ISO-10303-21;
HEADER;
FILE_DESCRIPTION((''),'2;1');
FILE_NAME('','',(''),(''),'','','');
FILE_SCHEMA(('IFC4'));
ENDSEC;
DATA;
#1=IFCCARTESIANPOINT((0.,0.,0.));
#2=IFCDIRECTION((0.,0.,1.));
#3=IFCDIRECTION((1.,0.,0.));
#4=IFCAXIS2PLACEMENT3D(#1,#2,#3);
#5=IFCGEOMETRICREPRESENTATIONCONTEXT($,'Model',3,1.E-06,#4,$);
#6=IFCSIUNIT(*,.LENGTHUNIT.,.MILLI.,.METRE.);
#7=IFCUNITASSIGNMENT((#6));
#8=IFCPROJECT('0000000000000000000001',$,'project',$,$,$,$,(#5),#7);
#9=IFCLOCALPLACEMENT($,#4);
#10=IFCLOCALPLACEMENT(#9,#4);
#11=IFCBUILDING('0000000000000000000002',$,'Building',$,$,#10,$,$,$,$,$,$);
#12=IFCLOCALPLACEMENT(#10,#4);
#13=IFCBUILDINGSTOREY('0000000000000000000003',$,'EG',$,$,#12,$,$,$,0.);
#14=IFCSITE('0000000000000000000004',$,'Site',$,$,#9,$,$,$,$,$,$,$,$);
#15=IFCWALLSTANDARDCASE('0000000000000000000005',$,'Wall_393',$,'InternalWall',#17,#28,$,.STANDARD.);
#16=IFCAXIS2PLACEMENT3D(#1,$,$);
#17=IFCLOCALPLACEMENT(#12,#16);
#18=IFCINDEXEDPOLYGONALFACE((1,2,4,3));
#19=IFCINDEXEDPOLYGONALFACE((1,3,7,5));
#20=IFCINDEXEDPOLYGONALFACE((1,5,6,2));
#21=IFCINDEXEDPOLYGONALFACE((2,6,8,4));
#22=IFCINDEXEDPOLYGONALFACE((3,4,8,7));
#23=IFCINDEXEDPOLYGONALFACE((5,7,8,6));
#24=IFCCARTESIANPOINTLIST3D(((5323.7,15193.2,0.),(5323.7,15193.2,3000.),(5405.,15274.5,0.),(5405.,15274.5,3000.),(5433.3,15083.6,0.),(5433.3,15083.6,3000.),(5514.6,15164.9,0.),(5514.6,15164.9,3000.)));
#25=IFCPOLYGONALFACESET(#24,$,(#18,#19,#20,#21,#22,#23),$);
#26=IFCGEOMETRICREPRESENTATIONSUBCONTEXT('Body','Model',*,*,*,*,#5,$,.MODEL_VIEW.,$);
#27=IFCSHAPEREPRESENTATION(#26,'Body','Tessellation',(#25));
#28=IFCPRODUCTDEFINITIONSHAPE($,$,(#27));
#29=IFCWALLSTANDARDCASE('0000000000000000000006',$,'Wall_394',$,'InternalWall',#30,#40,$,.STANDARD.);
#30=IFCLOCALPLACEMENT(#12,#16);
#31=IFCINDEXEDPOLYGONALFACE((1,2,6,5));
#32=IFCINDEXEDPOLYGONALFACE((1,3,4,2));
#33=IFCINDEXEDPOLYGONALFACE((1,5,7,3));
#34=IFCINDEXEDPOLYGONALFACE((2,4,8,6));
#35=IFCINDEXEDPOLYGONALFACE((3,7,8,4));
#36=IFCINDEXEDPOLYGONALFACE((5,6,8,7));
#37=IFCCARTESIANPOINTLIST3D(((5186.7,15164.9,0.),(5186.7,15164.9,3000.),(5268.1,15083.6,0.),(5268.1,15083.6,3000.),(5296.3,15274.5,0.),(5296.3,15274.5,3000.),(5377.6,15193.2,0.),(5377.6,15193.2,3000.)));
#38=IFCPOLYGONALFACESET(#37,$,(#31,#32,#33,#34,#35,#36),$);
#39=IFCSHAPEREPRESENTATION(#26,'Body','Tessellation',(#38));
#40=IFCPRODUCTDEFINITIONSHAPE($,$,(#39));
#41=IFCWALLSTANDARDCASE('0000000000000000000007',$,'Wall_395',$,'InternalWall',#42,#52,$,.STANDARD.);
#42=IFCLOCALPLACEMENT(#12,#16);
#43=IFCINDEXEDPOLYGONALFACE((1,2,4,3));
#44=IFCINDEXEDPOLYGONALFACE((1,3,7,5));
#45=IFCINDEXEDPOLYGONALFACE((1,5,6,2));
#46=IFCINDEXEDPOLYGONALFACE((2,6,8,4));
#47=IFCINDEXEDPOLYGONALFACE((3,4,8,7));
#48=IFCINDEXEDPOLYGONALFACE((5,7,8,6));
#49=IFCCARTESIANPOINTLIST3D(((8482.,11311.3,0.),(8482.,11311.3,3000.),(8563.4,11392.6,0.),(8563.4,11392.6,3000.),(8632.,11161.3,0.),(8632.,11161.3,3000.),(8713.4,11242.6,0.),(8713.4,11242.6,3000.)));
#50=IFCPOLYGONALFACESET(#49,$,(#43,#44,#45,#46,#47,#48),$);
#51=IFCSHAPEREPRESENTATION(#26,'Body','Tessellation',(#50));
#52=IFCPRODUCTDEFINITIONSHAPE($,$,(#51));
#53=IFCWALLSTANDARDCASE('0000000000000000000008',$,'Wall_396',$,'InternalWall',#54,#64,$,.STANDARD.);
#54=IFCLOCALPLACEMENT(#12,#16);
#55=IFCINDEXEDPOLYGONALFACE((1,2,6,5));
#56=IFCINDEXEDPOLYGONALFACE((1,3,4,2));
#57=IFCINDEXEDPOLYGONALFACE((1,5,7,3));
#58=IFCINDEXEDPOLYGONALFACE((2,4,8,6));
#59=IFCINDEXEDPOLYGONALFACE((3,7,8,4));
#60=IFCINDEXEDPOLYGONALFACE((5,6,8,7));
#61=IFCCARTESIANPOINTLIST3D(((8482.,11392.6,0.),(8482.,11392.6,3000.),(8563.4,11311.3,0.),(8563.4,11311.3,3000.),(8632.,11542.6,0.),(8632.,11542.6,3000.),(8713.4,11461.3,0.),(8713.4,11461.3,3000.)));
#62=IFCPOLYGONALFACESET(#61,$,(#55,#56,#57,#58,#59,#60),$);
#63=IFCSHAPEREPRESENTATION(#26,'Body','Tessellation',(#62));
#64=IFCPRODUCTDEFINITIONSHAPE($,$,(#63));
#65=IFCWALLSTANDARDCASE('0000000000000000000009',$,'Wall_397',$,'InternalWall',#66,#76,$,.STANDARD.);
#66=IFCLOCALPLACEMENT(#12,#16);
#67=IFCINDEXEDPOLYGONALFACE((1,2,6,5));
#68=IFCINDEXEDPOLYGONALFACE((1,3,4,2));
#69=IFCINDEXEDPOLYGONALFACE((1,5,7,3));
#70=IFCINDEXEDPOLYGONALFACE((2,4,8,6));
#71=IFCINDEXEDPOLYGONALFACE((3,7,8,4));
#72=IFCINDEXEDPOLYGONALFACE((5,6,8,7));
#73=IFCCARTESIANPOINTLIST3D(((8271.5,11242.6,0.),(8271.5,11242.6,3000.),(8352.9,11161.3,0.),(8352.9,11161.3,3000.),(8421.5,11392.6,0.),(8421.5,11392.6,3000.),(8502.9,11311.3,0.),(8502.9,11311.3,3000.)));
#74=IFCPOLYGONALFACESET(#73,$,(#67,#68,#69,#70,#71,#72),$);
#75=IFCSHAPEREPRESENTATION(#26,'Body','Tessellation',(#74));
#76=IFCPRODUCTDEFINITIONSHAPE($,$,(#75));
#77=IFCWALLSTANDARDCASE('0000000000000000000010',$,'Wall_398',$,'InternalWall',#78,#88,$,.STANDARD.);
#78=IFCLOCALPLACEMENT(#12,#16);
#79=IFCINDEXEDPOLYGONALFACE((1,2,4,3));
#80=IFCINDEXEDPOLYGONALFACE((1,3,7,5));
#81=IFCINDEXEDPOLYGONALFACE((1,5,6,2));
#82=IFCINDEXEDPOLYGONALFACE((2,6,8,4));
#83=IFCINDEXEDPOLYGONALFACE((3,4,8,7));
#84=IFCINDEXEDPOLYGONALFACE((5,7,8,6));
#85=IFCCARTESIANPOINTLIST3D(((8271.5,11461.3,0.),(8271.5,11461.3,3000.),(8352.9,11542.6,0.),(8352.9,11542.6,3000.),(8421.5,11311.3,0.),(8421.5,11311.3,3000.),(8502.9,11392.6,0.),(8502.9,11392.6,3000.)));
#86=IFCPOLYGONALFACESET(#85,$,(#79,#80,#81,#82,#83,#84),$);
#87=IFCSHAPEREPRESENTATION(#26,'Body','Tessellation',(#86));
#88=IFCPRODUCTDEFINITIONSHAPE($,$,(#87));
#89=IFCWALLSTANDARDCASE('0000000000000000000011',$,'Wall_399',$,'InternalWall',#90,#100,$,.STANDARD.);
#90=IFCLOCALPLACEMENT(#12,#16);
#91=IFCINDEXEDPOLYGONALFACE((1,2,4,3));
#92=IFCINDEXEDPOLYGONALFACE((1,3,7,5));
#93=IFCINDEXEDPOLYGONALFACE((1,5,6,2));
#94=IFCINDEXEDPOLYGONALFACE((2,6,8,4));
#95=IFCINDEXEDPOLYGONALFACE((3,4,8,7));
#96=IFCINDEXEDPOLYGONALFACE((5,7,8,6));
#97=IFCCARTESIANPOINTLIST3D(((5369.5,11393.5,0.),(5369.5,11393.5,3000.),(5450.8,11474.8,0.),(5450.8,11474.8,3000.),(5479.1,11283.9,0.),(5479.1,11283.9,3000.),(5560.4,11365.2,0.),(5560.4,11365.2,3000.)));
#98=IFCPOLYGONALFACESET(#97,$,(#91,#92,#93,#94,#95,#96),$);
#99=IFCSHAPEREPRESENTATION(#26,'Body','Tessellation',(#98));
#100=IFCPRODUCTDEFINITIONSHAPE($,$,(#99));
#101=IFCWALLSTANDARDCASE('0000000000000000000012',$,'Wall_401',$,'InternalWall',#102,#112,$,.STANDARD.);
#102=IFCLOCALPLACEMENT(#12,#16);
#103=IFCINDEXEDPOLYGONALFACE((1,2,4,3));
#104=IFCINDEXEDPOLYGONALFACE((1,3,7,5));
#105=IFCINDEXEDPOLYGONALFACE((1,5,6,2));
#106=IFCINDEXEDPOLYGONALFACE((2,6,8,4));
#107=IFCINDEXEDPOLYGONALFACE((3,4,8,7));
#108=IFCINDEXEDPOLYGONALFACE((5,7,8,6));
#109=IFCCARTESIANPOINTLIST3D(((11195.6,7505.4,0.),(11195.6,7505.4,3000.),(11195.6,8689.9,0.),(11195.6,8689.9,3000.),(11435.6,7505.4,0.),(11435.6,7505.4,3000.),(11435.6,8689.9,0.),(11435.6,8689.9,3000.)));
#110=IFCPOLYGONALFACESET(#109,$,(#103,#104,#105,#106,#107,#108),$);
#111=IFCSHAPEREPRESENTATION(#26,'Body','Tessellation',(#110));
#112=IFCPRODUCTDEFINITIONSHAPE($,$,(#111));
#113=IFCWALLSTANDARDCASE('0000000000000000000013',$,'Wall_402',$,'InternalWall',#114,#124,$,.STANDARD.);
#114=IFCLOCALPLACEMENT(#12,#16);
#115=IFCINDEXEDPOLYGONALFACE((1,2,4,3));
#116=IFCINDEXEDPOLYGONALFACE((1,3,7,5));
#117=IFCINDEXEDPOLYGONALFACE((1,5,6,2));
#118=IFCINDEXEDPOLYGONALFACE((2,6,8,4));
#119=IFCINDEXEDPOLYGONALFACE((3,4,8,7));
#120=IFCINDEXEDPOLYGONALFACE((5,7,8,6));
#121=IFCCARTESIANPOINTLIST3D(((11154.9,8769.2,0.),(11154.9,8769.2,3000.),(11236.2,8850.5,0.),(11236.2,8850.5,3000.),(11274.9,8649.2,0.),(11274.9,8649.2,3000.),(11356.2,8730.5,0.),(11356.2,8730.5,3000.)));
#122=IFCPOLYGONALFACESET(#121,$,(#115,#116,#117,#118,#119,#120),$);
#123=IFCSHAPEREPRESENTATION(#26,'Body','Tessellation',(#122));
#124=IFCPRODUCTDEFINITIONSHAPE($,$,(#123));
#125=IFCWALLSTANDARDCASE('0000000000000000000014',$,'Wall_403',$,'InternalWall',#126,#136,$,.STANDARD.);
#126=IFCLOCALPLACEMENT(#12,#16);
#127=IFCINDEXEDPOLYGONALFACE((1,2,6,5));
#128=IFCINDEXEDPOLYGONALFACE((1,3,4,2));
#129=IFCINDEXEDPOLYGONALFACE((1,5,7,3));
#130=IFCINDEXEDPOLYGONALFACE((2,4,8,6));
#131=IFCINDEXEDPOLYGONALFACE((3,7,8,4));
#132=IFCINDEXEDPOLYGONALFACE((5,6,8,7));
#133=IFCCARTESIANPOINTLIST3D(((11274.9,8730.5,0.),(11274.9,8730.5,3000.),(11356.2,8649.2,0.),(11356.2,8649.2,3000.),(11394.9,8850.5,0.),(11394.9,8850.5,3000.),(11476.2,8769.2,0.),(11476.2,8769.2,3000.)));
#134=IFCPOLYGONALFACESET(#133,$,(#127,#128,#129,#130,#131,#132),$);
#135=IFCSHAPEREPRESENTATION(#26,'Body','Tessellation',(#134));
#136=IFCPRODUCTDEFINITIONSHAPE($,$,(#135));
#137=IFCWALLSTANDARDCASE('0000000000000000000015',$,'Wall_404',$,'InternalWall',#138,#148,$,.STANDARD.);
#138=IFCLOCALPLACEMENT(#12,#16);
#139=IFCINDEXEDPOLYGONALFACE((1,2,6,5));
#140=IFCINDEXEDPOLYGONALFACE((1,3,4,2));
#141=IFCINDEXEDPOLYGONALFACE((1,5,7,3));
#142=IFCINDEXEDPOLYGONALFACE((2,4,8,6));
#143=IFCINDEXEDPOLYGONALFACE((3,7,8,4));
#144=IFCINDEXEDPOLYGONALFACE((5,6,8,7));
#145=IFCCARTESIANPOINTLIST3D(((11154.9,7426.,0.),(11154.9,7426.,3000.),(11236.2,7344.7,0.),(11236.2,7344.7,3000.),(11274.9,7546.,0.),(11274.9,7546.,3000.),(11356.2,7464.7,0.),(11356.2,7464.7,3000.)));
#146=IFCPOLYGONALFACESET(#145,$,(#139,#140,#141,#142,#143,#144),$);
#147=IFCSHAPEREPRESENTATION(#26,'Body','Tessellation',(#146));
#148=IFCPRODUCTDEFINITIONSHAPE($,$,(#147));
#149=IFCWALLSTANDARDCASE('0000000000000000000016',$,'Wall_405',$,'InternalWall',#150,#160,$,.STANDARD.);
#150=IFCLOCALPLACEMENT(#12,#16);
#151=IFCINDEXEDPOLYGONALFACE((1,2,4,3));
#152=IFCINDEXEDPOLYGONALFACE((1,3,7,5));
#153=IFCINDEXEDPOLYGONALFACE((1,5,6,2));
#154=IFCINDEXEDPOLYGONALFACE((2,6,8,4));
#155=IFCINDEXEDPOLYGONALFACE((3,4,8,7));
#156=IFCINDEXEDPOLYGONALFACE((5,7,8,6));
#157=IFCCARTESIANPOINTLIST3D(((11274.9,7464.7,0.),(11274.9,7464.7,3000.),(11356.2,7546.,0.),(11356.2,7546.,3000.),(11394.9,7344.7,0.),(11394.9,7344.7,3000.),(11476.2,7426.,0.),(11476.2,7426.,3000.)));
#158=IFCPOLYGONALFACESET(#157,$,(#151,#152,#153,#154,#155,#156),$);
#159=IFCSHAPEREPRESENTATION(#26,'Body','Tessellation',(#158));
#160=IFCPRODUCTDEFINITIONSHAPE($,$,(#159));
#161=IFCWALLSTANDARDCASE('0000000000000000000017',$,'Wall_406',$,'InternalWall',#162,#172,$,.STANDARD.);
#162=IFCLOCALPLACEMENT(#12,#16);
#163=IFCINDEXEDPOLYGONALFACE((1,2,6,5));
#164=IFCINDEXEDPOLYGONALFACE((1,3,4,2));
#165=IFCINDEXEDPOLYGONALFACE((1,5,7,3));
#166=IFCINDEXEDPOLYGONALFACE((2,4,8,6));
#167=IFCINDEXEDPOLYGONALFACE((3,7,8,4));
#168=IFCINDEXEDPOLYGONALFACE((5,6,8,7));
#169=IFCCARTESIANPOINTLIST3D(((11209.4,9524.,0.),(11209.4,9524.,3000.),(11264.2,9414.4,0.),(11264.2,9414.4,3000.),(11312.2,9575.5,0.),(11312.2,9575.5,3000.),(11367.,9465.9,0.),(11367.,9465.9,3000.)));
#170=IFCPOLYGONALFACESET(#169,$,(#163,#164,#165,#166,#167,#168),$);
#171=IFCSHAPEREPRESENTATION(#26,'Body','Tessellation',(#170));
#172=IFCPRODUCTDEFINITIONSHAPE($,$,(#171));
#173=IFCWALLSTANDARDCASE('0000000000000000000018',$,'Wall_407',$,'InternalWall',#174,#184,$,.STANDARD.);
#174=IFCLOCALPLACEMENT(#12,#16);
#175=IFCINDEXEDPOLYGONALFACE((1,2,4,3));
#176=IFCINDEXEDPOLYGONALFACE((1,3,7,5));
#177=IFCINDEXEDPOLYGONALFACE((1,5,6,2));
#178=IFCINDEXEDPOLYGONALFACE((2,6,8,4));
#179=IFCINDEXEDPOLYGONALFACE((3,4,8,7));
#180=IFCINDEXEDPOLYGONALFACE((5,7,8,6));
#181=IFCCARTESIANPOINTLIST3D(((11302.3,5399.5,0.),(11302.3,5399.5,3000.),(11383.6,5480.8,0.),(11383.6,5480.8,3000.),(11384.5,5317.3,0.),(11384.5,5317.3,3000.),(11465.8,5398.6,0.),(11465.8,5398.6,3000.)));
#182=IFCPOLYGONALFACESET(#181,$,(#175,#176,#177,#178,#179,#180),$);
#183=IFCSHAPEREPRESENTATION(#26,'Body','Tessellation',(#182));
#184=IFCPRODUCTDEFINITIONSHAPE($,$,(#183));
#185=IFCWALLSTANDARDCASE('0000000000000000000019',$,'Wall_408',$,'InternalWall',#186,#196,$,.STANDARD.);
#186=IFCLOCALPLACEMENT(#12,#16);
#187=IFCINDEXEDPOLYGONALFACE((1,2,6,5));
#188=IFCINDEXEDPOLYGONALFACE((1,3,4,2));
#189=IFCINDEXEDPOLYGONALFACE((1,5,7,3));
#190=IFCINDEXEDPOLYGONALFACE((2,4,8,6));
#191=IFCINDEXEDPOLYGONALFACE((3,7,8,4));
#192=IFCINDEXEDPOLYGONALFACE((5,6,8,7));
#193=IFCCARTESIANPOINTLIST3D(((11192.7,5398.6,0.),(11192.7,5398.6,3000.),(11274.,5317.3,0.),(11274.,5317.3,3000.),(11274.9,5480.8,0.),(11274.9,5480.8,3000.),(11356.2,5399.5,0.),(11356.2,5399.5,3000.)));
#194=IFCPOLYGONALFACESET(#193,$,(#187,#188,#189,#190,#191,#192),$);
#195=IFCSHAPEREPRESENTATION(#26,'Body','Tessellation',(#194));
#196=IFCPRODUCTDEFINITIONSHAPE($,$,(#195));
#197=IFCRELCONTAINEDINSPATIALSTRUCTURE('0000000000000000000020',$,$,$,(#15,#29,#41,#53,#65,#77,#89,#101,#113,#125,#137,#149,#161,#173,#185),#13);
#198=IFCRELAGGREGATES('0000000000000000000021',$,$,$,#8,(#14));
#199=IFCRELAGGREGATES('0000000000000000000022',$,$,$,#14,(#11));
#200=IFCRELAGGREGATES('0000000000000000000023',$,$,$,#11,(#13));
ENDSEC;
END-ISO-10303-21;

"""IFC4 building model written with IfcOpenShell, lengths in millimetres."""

from ifc_helpers import new_model, si_unit, frame, origin_with_axes, place, context, subcontext, project, spatial, rectangle, extrude, element, save


model = new_model("IFC4")

# Units and contexts
model_context = context("Model", 3, precision=1e-06, world=origin_with_axes())
body_context = subcontext(model_context, "Body", "Model", "MODEL_VIEW")
ifc_project = project(units=[si_unit("LENGTHUNIT", "METRE", prefix="MILLI")], contexts=[model_context])

# Site, building, storey
site_placement = place(None, origin_with_axes())
site = spatial("IfcSite", under=ifc_project, at=site_placement, Name="Site")
building_placement = place(site_placement, origin_with_axes())
building = spatial("IfcBuilding", under=site, at=building_placement, Name="Building")
storey_placement = place(building_placement, origin_with_axes())
storey = spatial("IfcBuildingStorey", under=building, at=storey_placement, Name="EG", Elevation=0.0)

# Walls
wall_1_placement = place(storey_placement, origin_with_axes())
element("IfcWallStandardCase", 1, at=wall_1_placement, inside=storey, Name="Wall_393", ObjectType="InternalWall", PredefinedType="STANDARD", context=body_context, shape_type="SweptSolid", body=[
    extrude(rectangle(XDim=155.0, YDim=115.0), frame((5419.2, 15179.0, 0.0), z_axis=(0.0, 0.0, 1.0), x_axis=(-0.707107, 0.707107, 0.0)), (0.0, 0.0, 1.0), 3000.0),
])
wall_2_placement = place(storey_placement, origin_with_axes())
element("IfcWallStandardCase", 2, at=wall_2_placement, inside=storey, Name="Wall_394", ObjectType="InternalWall", PredefinedType="STANDARD", context=body_context, shape_type="SweptSolid", body=[
    extrude(rectangle(XDim=155.0, YDim=115.0), frame((5282.2, 15179.0, 0.0), z_axis=(0.0, 0.0, 1.0), x_axis=(0.707107, 0.707107, 0.0)), (0.0, 0.0, 1.0), 3000.0),
])
wall_3_placement = place(storey_placement, origin_with_axes())
element("IfcWallStandardCase", 3, at=wall_3_placement, inside=storey, Name="Wall_395", ObjectType="InternalWall", PredefinedType="STANDARD", context=body_context, shape_type="SweptSolid", body=[
    extrude(rectangle(XDim=212.1, YDim=115.0), frame((8597.7, 11277.0, 0.0), z_axis=(0.0, 0.0, 1.0), x_axis=(0.707107, -0.707107, 0.0)), (0.0, 0.0, 1.0), 3000.0),
])
wall_4_placement = place(storey_placement, origin_with_axes())
element("IfcWallStandardCase", 4, at=wall_4_placement, inside=storey, Name="Wall_396", ObjectType="InternalWall", PredefinedType="STANDARD", context=body_context, shape_type="SweptSolid", body=[
    extrude(rectangle(XDim=212.1, YDim=115.0), frame((8597.7, 11427.0, 0.0), z_axis=(0.0, 0.0, 1.0), x_axis=(0.707107, 0.707107, 0.0)), (0.0, 0.0, 1.0), 3000.0),
])
wall_5_placement = place(storey_placement, origin_with_axes())
element("IfcWallStandardCase", 5, at=wall_5_placement, inside=storey, Name="Wall_397", ObjectType="InternalWall", PredefinedType="STANDARD", context=body_context, shape_type="SweptSolid", body=[
    extrude(rectangle(XDim=212.1, YDim=115.0), frame((8387.2, 11277.0, 0.0), z_axis=(0.0, 0.0, 1.0), x_axis=(-0.707107, -0.707107, 0.0)), (0.0, 0.0, 1.0), 3000.0),
])
wall_6_placement = place(storey_placement, origin_with_axes())
element("IfcWallStandardCase", 6, at=wall_6_placement, inside=storey, Name="Wall_398", ObjectType="InternalWall", PredefinedType="STANDARD", context=body_context, shape_type="SweptSolid", body=[
    extrude(rectangle(XDim=212.1, YDim=115.0), frame((8387.2, 11427.0, 0.0), z_axis=(0.0, 0.0, 1.0), x_axis=(-0.707107, 0.707107, 0.0)), (0.0, 0.0, 1.0), 3000.0),
])
wall_7_placement = place(storey_placement, origin_with_axes())
element("IfcWallStandardCase", 7, at=wall_7_placement, inside=storey, Name="Wall_399", ObjectType="InternalWall", PredefinedType="STANDARD", context=body_context, shape_type="SweptSolid", body=[
    extrude(rectangle(XDim=155.0, YDim=115.0), frame((5465.0, 11379.4, 0.0), z_axis=(0.0, 0.0, 1.0), x_axis=(-0.707107, 0.707107, 0.0)), (0.0, 0.0, 1.0), 3000.0),
])

# Walls
wall_8_placement = place(storey_placement, origin_with_axes())
element("IfcWallStandardCase", 8, at=wall_8_placement, inside=storey, Name="Wall_401", ObjectType="InternalWall", PredefinedType="STANDARD", context=body_context, shape_type="SweptSolid", body=[
    extrude(rectangle(XDim=1184.5, YDim=240.0), frame((11315.6, 8097.6, 0.0), z_axis=(0.0, 0.0, 1.0), x_axis=(0.0, -1.0, 0.0)), (0.0, 0.0, 1.0), 3000.0),
])
wall_9_placement = place(storey_placement, origin_with_axes())
element("IfcWallStandardCase", 9, at=wall_9_placement, inside=storey, Name="Wall_402", ObjectType="InternalWall", PredefinedType="STANDARD", context=body_context, shape_type="SweptSolid", body=[
    extrude(rectangle(XDim=169.7, YDim=115.0), frame((11255.6, 8749.9, 0.0), z_axis=(0.0, 0.0, 1.0), x_axis=(-0.707107, 0.707107, 0.0)), (0.0, 0.0, 1.0), 3000.0),
])
wall_10_placement = place(storey_placement, origin_with_axes())
element("IfcWallStandardCase", 10, at=wall_10_placement, inside=storey, Name="Wall_403", ObjectType="InternalWall", PredefinedType="STANDARD", context=body_context, shape_type="SweptSolid", body=[
    extrude(rectangle(XDim=169.7, YDim=115.0), frame((11375.6, 8749.9, 0.0), z_axis=(0.0, 0.0, 1.0), x_axis=(0.707107, 0.707107, 0.0)), (0.0, 0.0, 1.0), 3000.0),
])
wall_11_placement = place(storey_placement, origin_with_axes())
element("IfcWallStandardCase", 11, at=wall_11_placement, inside=storey, Name="Wall_404", ObjectType="InternalWall", PredefinedType="STANDARD", context=body_context, shape_type="SweptSolid", body=[
    extrude(rectangle(XDim=169.7, YDim=115.0), frame((11255.6, 7445.4, 0.0), z_axis=(0.0, 0.0, 1.0), x_axis=(-0.707107, -0.707107, 0.0)), (0.0, 0.0, 1.0), 3000.0),
])
wall_12_placement = place(storey_placement, origin_with_axes())
element("IfcWallStandardCase", 12, at=wall_12_placement, inside=storey, Name="Wall_405", ObjectType="InternalWall", PredefinedType="STANDARD", context=body_context, shape_type="SweptSolid", body=[
    extrude(rectangle(XDim=169.7, YDim=115.0), frame((11375.6, 7445.4, 0.0), z_axis=(0.0, 0.0, 1.0), x_axis=(0.707107, -0.707107, 0.0)), (0.0, 0.0, 1.0), 3000.0),
])
wall_13_placement = place(storey_placement, origin_with_axes())
element("IfcWallStandardCase", 13, at=wall_13_placement, inside=storey, Name="Wall_406", ObjectType="InternalWall", PredefinedType="STANDARD", context=body_context, shape_type="SweptSolid", body=[
    extrude(rectangle(XDim=122.5, YDim=115.0), frame((11288.2, 9494.9, 0.0), z_axis=(0.0, 0.0, 1.0), x_axis=(0.447214, -0.894427, 0.0)), (0.0, 0.0, 1.0), 3000.0),
])
wall_14_placement = place(storey_placement, origin_with_axes())
element("IfcWallStandardCase", 14, at=wall_14_placement, inside=storey, Name="Wall_407", ObjectType="InternalWall", PredefinedType="STANDARD", context=body_context, shape_type="SweptSolid", body=[
    extrude(rectangle(XDim=116.2, YDim=115.0), frame((11384.1, 5399.1, 0.0), z_axis=(0.0, 0.0, 1.0), x_axis=(-0.707107, 0.707107, 0.0)), (0.0, 0.0, 1.0), 3000.0),
])
wall_15_placement = place(storey_placement, origin_with_axes())
element("IfcWallStandardCase", 15, at=wall_15_placement, inside=storey, Name="Wall_408", ObjectType="InternalWall", PredefinedType="STANDARD", context=body_context, shape_type="SweptSolid", body=[
    extrude(rectangle(XDim=116.2, YDim=115.0), frame((11274.5, 5399.1, 0.0), z_axis=(0.0, 0.0, 1.0), x_axis=(-0.707107, -0.707107, 0.0)), (0.0, 0.0, 1.0), 3000.0),
])

save(model, "model.ifc")
